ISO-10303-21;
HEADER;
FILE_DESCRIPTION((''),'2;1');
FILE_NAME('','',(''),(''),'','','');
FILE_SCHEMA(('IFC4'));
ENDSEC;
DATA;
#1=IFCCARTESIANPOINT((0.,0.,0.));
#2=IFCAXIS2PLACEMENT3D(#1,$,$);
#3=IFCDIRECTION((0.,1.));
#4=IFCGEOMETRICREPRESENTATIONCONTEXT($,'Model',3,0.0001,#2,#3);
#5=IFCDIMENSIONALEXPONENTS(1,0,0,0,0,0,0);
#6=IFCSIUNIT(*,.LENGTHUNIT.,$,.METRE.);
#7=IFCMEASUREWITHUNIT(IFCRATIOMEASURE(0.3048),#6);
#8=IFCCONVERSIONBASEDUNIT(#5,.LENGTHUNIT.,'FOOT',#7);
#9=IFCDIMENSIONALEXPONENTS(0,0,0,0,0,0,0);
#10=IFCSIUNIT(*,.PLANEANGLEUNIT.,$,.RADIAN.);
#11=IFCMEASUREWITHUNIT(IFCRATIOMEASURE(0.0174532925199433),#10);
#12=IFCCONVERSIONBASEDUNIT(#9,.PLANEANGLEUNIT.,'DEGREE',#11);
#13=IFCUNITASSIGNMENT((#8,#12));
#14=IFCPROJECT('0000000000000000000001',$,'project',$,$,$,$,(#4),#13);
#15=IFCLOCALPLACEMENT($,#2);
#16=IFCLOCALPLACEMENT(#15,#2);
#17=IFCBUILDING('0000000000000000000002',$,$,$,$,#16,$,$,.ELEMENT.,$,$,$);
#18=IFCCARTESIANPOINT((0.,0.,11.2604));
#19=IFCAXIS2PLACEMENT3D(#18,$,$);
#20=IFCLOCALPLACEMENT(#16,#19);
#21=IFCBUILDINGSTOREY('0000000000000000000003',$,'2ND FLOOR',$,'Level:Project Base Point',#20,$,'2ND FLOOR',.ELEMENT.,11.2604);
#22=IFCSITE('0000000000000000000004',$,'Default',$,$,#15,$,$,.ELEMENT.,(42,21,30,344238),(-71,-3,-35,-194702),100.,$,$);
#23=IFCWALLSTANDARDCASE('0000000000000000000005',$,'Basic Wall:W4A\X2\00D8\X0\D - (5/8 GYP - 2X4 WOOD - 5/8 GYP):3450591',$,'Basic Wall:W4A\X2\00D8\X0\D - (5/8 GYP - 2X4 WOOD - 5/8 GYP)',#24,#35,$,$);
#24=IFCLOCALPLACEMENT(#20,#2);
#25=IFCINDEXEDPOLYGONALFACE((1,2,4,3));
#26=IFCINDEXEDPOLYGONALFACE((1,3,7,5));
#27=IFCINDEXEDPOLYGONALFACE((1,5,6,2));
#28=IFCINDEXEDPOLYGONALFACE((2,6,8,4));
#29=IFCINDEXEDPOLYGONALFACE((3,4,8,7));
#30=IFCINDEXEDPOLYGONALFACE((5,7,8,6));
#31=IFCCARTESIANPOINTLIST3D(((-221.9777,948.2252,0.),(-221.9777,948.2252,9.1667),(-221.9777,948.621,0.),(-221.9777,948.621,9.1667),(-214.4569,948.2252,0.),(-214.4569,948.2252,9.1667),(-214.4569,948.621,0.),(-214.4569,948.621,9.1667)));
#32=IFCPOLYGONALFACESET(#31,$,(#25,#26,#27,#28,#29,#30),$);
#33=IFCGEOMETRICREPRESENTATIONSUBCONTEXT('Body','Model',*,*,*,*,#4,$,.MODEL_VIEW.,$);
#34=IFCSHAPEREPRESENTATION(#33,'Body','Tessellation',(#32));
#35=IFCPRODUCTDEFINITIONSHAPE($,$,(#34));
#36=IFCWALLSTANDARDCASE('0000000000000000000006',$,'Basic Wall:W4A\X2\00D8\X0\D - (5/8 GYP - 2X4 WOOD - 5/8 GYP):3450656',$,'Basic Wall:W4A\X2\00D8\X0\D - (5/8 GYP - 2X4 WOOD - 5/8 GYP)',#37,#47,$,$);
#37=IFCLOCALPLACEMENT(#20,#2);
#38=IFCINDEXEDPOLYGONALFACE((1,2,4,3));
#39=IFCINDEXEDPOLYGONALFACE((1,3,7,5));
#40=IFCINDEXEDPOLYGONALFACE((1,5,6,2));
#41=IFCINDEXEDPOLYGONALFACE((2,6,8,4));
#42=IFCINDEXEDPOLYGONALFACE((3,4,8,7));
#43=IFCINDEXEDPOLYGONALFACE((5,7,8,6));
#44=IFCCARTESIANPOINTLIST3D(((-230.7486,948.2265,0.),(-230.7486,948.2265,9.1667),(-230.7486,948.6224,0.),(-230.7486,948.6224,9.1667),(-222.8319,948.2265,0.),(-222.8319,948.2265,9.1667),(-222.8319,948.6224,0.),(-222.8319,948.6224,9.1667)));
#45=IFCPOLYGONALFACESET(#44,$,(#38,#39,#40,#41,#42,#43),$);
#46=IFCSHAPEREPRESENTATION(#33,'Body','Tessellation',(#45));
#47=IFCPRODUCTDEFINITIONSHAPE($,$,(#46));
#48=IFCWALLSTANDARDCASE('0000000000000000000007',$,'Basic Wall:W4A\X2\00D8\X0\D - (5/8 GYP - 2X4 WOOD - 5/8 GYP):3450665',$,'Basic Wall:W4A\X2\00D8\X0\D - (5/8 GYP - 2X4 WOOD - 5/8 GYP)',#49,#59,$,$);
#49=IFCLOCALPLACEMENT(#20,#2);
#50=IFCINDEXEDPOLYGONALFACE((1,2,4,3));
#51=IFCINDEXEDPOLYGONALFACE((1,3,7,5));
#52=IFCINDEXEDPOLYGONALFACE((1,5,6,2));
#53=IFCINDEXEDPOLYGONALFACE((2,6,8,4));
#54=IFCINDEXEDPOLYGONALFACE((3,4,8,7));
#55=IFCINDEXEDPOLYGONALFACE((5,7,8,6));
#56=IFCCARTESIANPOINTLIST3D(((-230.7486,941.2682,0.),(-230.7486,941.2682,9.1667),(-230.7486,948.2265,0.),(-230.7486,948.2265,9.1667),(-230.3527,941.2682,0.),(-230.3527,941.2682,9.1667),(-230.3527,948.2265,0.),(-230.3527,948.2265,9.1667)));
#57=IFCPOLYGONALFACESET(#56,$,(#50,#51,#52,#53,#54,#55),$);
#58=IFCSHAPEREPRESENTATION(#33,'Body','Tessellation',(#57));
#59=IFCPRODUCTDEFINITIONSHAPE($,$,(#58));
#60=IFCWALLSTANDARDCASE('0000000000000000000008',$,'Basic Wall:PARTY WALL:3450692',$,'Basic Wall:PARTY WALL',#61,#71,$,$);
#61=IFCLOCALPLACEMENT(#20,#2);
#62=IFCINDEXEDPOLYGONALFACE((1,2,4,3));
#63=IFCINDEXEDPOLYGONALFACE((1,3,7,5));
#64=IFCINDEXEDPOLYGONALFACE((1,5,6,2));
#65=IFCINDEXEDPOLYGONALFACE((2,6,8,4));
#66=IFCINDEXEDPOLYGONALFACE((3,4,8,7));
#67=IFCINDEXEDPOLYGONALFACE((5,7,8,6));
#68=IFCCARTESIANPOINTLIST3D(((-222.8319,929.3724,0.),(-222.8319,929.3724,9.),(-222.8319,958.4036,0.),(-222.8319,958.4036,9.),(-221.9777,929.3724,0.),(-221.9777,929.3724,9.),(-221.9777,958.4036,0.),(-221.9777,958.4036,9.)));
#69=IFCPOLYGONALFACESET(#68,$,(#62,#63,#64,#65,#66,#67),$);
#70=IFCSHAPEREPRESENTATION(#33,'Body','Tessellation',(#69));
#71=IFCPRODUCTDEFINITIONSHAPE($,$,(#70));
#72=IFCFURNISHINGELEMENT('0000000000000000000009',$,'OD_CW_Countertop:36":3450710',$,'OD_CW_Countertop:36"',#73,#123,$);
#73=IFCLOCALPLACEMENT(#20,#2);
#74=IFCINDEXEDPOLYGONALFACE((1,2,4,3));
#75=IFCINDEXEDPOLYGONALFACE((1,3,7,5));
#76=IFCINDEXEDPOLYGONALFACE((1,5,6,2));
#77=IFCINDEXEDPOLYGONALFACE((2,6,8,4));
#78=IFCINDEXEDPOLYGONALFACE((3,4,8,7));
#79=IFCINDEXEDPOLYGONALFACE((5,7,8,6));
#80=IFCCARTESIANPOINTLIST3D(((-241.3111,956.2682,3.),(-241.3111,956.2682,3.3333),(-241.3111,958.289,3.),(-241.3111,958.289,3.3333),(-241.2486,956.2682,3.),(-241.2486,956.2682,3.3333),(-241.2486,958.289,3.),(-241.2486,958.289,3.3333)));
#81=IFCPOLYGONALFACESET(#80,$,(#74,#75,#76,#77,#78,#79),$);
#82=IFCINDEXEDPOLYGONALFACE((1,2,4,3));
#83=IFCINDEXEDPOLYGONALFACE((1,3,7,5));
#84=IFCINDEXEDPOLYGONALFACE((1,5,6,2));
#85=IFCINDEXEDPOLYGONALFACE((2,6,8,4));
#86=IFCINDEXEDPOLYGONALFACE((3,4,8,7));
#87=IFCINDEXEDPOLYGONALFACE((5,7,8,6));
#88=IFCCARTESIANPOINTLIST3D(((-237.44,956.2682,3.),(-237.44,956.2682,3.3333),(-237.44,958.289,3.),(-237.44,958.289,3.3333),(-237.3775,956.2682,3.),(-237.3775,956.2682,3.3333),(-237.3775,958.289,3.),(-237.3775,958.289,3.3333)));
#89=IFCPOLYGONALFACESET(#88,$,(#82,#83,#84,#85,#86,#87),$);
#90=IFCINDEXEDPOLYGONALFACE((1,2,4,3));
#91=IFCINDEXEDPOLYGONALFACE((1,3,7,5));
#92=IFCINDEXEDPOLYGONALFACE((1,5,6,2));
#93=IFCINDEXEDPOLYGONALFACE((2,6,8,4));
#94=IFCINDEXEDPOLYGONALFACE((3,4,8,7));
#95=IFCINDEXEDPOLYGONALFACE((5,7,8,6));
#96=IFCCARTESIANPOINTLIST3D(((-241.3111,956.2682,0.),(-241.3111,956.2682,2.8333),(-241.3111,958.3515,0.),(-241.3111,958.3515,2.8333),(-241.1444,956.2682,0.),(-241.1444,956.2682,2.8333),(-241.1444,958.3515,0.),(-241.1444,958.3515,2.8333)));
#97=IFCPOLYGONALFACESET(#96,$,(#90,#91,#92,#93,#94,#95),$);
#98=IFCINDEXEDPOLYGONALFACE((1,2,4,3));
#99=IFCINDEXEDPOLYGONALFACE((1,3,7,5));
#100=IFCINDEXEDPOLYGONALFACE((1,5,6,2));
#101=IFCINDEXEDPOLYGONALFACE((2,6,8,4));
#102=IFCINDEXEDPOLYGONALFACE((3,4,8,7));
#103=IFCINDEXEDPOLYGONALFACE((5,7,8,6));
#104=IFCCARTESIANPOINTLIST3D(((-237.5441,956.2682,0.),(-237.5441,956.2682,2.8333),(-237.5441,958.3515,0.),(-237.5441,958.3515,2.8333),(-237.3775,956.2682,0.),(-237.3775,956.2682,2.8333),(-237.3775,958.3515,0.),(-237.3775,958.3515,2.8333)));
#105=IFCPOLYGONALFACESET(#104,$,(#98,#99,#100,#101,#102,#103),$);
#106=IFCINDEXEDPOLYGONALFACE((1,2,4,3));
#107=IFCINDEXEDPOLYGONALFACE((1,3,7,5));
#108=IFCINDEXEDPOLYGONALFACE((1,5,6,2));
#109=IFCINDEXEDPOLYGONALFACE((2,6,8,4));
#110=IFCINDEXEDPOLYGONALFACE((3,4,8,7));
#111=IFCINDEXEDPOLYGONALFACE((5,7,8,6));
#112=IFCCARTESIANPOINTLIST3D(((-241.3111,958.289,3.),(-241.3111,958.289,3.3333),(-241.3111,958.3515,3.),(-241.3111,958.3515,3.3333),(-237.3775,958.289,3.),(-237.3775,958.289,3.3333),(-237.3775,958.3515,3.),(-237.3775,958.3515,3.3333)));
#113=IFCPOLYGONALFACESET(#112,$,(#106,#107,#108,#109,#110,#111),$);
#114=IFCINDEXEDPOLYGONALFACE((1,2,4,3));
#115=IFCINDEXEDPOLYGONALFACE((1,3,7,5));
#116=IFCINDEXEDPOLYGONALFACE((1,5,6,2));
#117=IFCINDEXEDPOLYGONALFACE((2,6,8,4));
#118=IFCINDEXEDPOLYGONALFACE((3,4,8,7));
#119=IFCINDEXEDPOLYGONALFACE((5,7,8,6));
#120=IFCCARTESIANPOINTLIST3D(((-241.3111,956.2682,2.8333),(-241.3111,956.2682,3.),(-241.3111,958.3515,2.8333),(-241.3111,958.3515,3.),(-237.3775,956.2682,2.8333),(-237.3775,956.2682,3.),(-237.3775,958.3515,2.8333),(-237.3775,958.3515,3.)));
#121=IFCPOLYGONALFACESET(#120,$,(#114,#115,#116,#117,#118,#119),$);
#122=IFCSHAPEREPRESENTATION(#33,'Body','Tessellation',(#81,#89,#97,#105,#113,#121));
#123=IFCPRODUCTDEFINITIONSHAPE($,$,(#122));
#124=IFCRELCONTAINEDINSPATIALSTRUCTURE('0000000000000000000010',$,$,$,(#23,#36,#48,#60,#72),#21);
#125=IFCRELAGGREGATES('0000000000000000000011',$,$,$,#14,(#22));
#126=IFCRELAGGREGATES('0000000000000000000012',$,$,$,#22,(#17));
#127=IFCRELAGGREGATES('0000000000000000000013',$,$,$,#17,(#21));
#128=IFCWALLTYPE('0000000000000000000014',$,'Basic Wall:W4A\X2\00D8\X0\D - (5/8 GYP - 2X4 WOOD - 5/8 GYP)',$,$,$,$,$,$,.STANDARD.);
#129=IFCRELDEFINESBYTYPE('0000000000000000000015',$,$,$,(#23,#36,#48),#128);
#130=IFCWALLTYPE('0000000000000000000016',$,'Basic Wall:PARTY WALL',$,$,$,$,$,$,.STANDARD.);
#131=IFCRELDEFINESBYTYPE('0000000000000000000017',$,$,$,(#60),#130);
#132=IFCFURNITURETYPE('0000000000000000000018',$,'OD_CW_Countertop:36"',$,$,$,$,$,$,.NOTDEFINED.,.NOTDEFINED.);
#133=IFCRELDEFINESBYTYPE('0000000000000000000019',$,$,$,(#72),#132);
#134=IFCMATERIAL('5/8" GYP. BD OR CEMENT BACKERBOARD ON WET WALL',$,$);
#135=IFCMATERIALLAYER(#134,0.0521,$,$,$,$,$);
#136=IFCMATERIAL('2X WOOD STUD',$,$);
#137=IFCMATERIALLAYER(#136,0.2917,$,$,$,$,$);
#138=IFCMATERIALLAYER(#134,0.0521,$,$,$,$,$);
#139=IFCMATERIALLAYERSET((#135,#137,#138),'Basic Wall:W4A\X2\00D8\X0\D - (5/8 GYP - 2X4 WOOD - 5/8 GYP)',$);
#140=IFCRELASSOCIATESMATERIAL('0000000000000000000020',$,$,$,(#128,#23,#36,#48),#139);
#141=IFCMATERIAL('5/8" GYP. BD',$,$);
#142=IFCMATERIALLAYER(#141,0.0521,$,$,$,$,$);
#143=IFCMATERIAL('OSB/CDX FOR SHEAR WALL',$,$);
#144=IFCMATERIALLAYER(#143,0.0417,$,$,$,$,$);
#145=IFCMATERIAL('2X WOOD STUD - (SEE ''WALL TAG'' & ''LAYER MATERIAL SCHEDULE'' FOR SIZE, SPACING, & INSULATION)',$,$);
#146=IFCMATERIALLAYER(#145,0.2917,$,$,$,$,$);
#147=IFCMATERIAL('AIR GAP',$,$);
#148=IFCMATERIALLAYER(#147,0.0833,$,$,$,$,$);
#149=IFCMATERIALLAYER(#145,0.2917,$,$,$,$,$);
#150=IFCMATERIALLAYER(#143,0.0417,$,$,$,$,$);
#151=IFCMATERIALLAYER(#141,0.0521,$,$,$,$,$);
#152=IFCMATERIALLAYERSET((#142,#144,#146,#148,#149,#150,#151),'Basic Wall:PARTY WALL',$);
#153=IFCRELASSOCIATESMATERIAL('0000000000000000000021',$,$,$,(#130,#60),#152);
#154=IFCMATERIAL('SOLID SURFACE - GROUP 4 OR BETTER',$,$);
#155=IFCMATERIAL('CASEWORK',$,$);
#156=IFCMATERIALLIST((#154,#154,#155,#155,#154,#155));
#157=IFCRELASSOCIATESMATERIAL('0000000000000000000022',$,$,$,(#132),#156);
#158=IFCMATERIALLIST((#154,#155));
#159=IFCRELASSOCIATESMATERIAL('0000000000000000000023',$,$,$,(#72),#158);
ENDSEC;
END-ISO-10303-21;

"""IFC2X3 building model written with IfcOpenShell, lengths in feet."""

from ifc_helpers import new_model, entity, si_unit, converted_unit, direction, frame, frame_2d, origin, origin_2d_with_axis, place, context, subcontext, project, spatial, rectangle, extrude, source, transform, mapped, material, material_list, layer, layer_set, layer_usage, type_object, type_shapes, element, save


model = new_model("IFC2X3")

# Units and contexts
model_context = context("Model", 3, precision=0.0001, world=origin(), true_north=direction((0.0, 1.0)))
body_context = subcontext(model_context, "Body", "Model", "MODEL_VIEW")
ifc_project = project(units=[converted_unit("LENGTHUNIT", "FOOT", entity("IfcRatioMeasure", 0.3048), si_unit("LENGTHUNIT", "METRE"), dimensions=[1, 0, 0, 0, 0, 0, 0]), converted_unit("PLANEANGLEUNIT", "DEGREE", entity("IfcRatioMeasure", 0.0174532925199433), si_unit("PLANEANGLEUNIT", "RADIAN"), dimensions=[0, 0, 0, 0, 0, 0, 0])], contexts=[model_context])

# Site, building, storey
site_placement = place(None, origin())
site = spatial("IfcSite", under=ifc_project, at=site_placement, Name="Default", CompositionType="ELEMENT", RefLatitude=(42, 21, 30, 344238), RefLongitude=(-71, -3, -35, -194702), RefElevation=100.0)
building_placement = place(site_placement, origin())
building = spatial("IfcBuilding", under=site, at=building_placement, CompositionType="ELEMENT")
storey_placement = place(building_placement, frame((0.0, 0.0, 11.2604)))
storey = spatial("IfcBuildingStorey", under=building, at=storey_placement, Name="2ND FLOOR", ObjectType="Level:Project Base Point", LongName="2ND FLOOR", CompositionType="ELEMENT", Elevation=11.2604)

# Walls
ifc_material_1 = material(Name="5/8\" GYP. BD OR CEMENT BACKERBOARD ON WET WALL")
ifc_layer_1 = layer(ifc_material_1, 0.0521)
ifc_material_2 = material(Name="2X WOOD STUD")
ifc_layer_2 = layer(ifc_material_2, 0.2917)
ifc_layer_3 = layer(ifc_material_1, 0.0521)
ifc_layer_set_1 = layer_set([ifc_layer_1, ifc_layer_2, ifc_layer_3], Name="Basic Wall:W4AØD - (5/8 GYP - 2X4 WOOD - 5/8 GYP)")
ifc_layer_usage_1 = layer_usage(ifc_layer_set_1, "AXIS2", "POSITIVE", -0.1979)
wall_type_1 = type_object("IfcWallType", Name="Basic Wall:W4AØD - (5/8 GYP - 2X4 WOOD - 5/8 GYP)", PredefinedType="STANDARD", material=ifc_layer_set_1)
wall_1_placement = place(storey_placement, frame((-221.9777, 948.4231, 0.0)))
element("IfcWallStandardCase", 1, at=wall_1_placement, inside=storey, type_object=wall_type_1, material=ifc_layer_usage_1, Name="Basic Wall:W4AØD - (5/8 GYP - 2X4 WOOD - 5/8 GYP):3450591", ObjectType="Basic Wall:W4AØD - (5/8 GYP - 2X4 WOOD - 5/8 GYP)", context=body_context, shape_type="SweptSolid", body=[
    extrude(rectangle(XDim=7.5208, YDim=0.3958, at=frame_2d((3.7604, 0.0), x_axis=(-1.0, 0.0))), origin(), (0.0, 0.0, 1.0), 9.1667),
])
ifc_layer_usage_2 = layer_usage(ifc_layer_set_1, "AXIS2", "NEGATIVE", 0.1979)
wall_2_placement = place(storey_placement, frame((-222.8319, 948.4244, 0.0), z_axis=(0.0, 0.0, 1.0), x_axis=(-1.0, 0.0, 0.0)))
element("IfcWallStandardCase", 2, at=wall_2_placement, inside=storey, type_object=wall_type_1, material=ifc_layer_usage_2, Name="Basic Wall:W4AØD - (5/8 GYP - 2X4 WOOD - 5/8 GYP):3450656", ObjectType="Basic Wall:W4AØD - (5/8 GYP - 2X4 WOOD - 5/8 GYP)", context=body_context, shape_type="SweptSolid", body=[
    extrude(rectangle(XDim=7.9167, YDim=0.3958, at=frame_2d((3.9583, 0.0), x_axis=(-1.0, 0.0))), origin(), (0.0, 0.0, 1.0), 9.1667),
])

# Wall
ifc_layer_usage_3 = layer_usage(ifc_layer_set_1, "AXIS2", "NEGATIVE", 0.1979)
wall_3_placement = place(storey_placement, frame((-230.5507, 941.2682, 0.0), z_axis=(0.0, 0.0, 1.0), x_axis=(0.0, 1.0, 0.0)))
element("IfcWallStandardCase", 3, at=wall_3_placement, inside=storey, type_object=wall_type_1, material=ifc_layer_usage_3, Name="Basic Wall:W4AØD - (5/8 GYP - 2X4 WOOD - 5/8 GYP):3450665", ObjectType="Basic Wall:W4AØD - (5/8 GYP - 2X4 WOOD - 5/8 GYP)", context=body_context, shape_type="SweptSolid", body=[
    extrude(rectangle(XDim=6.9583, YDim=0.3958, at=frame_2d((3.4792, 0.0), x_axis=(-1.0, 0.0))), origin(), (0.0, 0.0, 1.0), 9.1667),
])

# Wall
ifc_material_3 = material(Name="5/8\" GYP. BD")
ifc_layer_4 = layer(ifc_material_3, 0.0521)
ifc_material_4 = material(Name="OSB/CDX FOR SHEAR WALL")
ifc_layer_5 = layer(ifc_material_4, 0.0417)
ifc_material_5 = material(Name="2X WOOD STUD - (SEE 'WALL TAG' & 'LAYER MATERIAL SCHEDULE' FOR SIZE, SPACING, & INSULATION)")
ifc_layer_6 = layer(ifc_material_5, 0.2917)
ifc_material_6 = material(Name="AIR GAP")
ifc_layer_7 = layer(ifc_material_6, 0.0833)
ifc_layer_8 = layer(ifc_material_5, 0.2917)
ifc_layer_9 = layer(ifc_material_4, 0.0417)
ifc_layer_10 = layer(ifc_material_3, 0.0521)
ifc_layer_set_2 = layer_set([ifc_layer_4, ifc_layer_5, ifc_layer_6, ifc_layer_7, ifc_layer_8, ifc_layer_9, ifc_layer_10], Name="Basic Wall:PARTY WALL")
ifc_layer_usage_4 = layer_usage(ifc_layer_set_2, "AXIS2", "NEGATIVE", 0.4271)
wall_type_2 = type_object("IfcWallType", Name="Basic Wall:PARTY WALL", PredefinedType="STANDARD", material=ifc_layer_set_2)
wall_4_placement = place(storey_placement, frame((-222.4048, 929.3724, 0.0), z_axis=(0.0, 0.0, 1.0), x_axis=(0.0, 1.0, 0.0)))
element("IfcWallStandardCase", 4, at=wall_4_placement, inside=storey, type_object=wall_type_2, material=ifc_layer_usage_4, Name="Basic Wall:PARTY WALL:3450692", ObjectType="Basic Wall:PARTY WALL", context=body_context, shape_type="SweptSolid", body=[
    extrude(rectangle(XDim=29.0313, YDim=0.8542, at=frame_2d((14.5156, 0.0), x_axis=(-1.0, 0.0))), origin(), (0.0, 0.0, 1.0), 9.0),
])

# Furnishing element
ifc_material_7 = material(Name="CASEWORK")
ifc_material_8 = material(Name="SOLID SURFACE - GROUP 4 OR BETTER")
ifc_material_list_1 = material_list([ifc_material_8, ifc_material_7])
ifc_material_list_2 = material_list([ifc_material_8, ifc_material_8, ifc_material_7, ifc_material_7, ifc_material_8, ifc_material_7])
furniture_type_1 = type_object("IfcFurnitureType", Name="OD_CW_Countertop:36\"", material=ifc_material_list_2)
shared_shape_1 = source(origin(), body_context, "Body", "SweptSolid", [
    extrude(rectangle(XDim=2.0208, YDim=0.0625, at=origin_2d_with_axis()), frame((3.9024, 1.0729, 3.0), z_axis=(0.0, 0.0, 1.0), x_axis=(0.0, 1.0, 0.0)), (0.0, 0.0, 1.0), 0.3333),
    extrude(rectangle(XDim=2.0208, YDim=0.0625, at=origin_2d_with_axis()), frame((0.0313, 1.0729, 3.0), z_axis=(0.0, 0.0, 1.0), x_axis=(0.0, 1.0, 0.0)), (0.0, 0.0, 1.0), 0.3333),
    extrude(rectangle(XDim=0.1667, YDim=2.0833, at=frame_2d((0.0, 0.0), x_axis=(1.0, 0.0))), frame((3.8503, 1.0417, 0.0)), (0.0, 0.0, 1.0), 2.8333),
    extrude(rectangle(XDim=0.1667, YDim=2.0833, at=frame_2d((0.0, 0.0), x_axis=(1.0, 0.0))), frame((0.0833, 1.0417, 0.0)), (0.0, 0.0, 1.0), 2.8333),
    extrude(rectangle(XDim=3.9336, YDim=0.0625, at=frame_2d((0.0, 0.0), x_axis=(1.0, 0.0))), frame((1.9668, 0.0313, 3.0)), (0.0, 0.0, 1.0), 0.3333),
    extrude(rectangle(XDim=3.9336, YDim=2.0833, at=origin_2d_with_axis()), frame((1.9668, 1.0417, 2.8333)), (0.0, 0.0, 1.0), 0.1667),
])
type_shapes(furniture_type_1, [shared_shape_1])
furnishing_1_placement = place(storey_placement, frame((-237.3775, 958.3515, 0.0), z_axis=(0.0, 0.0, 1.0), x_axis=(-1.0, 0.0, 0.0)))
element("IfcFurnishingElement", 5, at=furnishing_1_placement, inside=storey, type_object=furniture_type_1, material=ifc_material_list_1, Name="OD_CW_Countertop:36\":3450710", ObjectType="OD_CW_Countertop:36\"", context=body_context, shape_type="MappedRepresentation", body=[
    mapped(shared_shape_1, transform((0.0, 0.0, 0.0), scale=1.0)),
])

save(model, "model.ifc")
